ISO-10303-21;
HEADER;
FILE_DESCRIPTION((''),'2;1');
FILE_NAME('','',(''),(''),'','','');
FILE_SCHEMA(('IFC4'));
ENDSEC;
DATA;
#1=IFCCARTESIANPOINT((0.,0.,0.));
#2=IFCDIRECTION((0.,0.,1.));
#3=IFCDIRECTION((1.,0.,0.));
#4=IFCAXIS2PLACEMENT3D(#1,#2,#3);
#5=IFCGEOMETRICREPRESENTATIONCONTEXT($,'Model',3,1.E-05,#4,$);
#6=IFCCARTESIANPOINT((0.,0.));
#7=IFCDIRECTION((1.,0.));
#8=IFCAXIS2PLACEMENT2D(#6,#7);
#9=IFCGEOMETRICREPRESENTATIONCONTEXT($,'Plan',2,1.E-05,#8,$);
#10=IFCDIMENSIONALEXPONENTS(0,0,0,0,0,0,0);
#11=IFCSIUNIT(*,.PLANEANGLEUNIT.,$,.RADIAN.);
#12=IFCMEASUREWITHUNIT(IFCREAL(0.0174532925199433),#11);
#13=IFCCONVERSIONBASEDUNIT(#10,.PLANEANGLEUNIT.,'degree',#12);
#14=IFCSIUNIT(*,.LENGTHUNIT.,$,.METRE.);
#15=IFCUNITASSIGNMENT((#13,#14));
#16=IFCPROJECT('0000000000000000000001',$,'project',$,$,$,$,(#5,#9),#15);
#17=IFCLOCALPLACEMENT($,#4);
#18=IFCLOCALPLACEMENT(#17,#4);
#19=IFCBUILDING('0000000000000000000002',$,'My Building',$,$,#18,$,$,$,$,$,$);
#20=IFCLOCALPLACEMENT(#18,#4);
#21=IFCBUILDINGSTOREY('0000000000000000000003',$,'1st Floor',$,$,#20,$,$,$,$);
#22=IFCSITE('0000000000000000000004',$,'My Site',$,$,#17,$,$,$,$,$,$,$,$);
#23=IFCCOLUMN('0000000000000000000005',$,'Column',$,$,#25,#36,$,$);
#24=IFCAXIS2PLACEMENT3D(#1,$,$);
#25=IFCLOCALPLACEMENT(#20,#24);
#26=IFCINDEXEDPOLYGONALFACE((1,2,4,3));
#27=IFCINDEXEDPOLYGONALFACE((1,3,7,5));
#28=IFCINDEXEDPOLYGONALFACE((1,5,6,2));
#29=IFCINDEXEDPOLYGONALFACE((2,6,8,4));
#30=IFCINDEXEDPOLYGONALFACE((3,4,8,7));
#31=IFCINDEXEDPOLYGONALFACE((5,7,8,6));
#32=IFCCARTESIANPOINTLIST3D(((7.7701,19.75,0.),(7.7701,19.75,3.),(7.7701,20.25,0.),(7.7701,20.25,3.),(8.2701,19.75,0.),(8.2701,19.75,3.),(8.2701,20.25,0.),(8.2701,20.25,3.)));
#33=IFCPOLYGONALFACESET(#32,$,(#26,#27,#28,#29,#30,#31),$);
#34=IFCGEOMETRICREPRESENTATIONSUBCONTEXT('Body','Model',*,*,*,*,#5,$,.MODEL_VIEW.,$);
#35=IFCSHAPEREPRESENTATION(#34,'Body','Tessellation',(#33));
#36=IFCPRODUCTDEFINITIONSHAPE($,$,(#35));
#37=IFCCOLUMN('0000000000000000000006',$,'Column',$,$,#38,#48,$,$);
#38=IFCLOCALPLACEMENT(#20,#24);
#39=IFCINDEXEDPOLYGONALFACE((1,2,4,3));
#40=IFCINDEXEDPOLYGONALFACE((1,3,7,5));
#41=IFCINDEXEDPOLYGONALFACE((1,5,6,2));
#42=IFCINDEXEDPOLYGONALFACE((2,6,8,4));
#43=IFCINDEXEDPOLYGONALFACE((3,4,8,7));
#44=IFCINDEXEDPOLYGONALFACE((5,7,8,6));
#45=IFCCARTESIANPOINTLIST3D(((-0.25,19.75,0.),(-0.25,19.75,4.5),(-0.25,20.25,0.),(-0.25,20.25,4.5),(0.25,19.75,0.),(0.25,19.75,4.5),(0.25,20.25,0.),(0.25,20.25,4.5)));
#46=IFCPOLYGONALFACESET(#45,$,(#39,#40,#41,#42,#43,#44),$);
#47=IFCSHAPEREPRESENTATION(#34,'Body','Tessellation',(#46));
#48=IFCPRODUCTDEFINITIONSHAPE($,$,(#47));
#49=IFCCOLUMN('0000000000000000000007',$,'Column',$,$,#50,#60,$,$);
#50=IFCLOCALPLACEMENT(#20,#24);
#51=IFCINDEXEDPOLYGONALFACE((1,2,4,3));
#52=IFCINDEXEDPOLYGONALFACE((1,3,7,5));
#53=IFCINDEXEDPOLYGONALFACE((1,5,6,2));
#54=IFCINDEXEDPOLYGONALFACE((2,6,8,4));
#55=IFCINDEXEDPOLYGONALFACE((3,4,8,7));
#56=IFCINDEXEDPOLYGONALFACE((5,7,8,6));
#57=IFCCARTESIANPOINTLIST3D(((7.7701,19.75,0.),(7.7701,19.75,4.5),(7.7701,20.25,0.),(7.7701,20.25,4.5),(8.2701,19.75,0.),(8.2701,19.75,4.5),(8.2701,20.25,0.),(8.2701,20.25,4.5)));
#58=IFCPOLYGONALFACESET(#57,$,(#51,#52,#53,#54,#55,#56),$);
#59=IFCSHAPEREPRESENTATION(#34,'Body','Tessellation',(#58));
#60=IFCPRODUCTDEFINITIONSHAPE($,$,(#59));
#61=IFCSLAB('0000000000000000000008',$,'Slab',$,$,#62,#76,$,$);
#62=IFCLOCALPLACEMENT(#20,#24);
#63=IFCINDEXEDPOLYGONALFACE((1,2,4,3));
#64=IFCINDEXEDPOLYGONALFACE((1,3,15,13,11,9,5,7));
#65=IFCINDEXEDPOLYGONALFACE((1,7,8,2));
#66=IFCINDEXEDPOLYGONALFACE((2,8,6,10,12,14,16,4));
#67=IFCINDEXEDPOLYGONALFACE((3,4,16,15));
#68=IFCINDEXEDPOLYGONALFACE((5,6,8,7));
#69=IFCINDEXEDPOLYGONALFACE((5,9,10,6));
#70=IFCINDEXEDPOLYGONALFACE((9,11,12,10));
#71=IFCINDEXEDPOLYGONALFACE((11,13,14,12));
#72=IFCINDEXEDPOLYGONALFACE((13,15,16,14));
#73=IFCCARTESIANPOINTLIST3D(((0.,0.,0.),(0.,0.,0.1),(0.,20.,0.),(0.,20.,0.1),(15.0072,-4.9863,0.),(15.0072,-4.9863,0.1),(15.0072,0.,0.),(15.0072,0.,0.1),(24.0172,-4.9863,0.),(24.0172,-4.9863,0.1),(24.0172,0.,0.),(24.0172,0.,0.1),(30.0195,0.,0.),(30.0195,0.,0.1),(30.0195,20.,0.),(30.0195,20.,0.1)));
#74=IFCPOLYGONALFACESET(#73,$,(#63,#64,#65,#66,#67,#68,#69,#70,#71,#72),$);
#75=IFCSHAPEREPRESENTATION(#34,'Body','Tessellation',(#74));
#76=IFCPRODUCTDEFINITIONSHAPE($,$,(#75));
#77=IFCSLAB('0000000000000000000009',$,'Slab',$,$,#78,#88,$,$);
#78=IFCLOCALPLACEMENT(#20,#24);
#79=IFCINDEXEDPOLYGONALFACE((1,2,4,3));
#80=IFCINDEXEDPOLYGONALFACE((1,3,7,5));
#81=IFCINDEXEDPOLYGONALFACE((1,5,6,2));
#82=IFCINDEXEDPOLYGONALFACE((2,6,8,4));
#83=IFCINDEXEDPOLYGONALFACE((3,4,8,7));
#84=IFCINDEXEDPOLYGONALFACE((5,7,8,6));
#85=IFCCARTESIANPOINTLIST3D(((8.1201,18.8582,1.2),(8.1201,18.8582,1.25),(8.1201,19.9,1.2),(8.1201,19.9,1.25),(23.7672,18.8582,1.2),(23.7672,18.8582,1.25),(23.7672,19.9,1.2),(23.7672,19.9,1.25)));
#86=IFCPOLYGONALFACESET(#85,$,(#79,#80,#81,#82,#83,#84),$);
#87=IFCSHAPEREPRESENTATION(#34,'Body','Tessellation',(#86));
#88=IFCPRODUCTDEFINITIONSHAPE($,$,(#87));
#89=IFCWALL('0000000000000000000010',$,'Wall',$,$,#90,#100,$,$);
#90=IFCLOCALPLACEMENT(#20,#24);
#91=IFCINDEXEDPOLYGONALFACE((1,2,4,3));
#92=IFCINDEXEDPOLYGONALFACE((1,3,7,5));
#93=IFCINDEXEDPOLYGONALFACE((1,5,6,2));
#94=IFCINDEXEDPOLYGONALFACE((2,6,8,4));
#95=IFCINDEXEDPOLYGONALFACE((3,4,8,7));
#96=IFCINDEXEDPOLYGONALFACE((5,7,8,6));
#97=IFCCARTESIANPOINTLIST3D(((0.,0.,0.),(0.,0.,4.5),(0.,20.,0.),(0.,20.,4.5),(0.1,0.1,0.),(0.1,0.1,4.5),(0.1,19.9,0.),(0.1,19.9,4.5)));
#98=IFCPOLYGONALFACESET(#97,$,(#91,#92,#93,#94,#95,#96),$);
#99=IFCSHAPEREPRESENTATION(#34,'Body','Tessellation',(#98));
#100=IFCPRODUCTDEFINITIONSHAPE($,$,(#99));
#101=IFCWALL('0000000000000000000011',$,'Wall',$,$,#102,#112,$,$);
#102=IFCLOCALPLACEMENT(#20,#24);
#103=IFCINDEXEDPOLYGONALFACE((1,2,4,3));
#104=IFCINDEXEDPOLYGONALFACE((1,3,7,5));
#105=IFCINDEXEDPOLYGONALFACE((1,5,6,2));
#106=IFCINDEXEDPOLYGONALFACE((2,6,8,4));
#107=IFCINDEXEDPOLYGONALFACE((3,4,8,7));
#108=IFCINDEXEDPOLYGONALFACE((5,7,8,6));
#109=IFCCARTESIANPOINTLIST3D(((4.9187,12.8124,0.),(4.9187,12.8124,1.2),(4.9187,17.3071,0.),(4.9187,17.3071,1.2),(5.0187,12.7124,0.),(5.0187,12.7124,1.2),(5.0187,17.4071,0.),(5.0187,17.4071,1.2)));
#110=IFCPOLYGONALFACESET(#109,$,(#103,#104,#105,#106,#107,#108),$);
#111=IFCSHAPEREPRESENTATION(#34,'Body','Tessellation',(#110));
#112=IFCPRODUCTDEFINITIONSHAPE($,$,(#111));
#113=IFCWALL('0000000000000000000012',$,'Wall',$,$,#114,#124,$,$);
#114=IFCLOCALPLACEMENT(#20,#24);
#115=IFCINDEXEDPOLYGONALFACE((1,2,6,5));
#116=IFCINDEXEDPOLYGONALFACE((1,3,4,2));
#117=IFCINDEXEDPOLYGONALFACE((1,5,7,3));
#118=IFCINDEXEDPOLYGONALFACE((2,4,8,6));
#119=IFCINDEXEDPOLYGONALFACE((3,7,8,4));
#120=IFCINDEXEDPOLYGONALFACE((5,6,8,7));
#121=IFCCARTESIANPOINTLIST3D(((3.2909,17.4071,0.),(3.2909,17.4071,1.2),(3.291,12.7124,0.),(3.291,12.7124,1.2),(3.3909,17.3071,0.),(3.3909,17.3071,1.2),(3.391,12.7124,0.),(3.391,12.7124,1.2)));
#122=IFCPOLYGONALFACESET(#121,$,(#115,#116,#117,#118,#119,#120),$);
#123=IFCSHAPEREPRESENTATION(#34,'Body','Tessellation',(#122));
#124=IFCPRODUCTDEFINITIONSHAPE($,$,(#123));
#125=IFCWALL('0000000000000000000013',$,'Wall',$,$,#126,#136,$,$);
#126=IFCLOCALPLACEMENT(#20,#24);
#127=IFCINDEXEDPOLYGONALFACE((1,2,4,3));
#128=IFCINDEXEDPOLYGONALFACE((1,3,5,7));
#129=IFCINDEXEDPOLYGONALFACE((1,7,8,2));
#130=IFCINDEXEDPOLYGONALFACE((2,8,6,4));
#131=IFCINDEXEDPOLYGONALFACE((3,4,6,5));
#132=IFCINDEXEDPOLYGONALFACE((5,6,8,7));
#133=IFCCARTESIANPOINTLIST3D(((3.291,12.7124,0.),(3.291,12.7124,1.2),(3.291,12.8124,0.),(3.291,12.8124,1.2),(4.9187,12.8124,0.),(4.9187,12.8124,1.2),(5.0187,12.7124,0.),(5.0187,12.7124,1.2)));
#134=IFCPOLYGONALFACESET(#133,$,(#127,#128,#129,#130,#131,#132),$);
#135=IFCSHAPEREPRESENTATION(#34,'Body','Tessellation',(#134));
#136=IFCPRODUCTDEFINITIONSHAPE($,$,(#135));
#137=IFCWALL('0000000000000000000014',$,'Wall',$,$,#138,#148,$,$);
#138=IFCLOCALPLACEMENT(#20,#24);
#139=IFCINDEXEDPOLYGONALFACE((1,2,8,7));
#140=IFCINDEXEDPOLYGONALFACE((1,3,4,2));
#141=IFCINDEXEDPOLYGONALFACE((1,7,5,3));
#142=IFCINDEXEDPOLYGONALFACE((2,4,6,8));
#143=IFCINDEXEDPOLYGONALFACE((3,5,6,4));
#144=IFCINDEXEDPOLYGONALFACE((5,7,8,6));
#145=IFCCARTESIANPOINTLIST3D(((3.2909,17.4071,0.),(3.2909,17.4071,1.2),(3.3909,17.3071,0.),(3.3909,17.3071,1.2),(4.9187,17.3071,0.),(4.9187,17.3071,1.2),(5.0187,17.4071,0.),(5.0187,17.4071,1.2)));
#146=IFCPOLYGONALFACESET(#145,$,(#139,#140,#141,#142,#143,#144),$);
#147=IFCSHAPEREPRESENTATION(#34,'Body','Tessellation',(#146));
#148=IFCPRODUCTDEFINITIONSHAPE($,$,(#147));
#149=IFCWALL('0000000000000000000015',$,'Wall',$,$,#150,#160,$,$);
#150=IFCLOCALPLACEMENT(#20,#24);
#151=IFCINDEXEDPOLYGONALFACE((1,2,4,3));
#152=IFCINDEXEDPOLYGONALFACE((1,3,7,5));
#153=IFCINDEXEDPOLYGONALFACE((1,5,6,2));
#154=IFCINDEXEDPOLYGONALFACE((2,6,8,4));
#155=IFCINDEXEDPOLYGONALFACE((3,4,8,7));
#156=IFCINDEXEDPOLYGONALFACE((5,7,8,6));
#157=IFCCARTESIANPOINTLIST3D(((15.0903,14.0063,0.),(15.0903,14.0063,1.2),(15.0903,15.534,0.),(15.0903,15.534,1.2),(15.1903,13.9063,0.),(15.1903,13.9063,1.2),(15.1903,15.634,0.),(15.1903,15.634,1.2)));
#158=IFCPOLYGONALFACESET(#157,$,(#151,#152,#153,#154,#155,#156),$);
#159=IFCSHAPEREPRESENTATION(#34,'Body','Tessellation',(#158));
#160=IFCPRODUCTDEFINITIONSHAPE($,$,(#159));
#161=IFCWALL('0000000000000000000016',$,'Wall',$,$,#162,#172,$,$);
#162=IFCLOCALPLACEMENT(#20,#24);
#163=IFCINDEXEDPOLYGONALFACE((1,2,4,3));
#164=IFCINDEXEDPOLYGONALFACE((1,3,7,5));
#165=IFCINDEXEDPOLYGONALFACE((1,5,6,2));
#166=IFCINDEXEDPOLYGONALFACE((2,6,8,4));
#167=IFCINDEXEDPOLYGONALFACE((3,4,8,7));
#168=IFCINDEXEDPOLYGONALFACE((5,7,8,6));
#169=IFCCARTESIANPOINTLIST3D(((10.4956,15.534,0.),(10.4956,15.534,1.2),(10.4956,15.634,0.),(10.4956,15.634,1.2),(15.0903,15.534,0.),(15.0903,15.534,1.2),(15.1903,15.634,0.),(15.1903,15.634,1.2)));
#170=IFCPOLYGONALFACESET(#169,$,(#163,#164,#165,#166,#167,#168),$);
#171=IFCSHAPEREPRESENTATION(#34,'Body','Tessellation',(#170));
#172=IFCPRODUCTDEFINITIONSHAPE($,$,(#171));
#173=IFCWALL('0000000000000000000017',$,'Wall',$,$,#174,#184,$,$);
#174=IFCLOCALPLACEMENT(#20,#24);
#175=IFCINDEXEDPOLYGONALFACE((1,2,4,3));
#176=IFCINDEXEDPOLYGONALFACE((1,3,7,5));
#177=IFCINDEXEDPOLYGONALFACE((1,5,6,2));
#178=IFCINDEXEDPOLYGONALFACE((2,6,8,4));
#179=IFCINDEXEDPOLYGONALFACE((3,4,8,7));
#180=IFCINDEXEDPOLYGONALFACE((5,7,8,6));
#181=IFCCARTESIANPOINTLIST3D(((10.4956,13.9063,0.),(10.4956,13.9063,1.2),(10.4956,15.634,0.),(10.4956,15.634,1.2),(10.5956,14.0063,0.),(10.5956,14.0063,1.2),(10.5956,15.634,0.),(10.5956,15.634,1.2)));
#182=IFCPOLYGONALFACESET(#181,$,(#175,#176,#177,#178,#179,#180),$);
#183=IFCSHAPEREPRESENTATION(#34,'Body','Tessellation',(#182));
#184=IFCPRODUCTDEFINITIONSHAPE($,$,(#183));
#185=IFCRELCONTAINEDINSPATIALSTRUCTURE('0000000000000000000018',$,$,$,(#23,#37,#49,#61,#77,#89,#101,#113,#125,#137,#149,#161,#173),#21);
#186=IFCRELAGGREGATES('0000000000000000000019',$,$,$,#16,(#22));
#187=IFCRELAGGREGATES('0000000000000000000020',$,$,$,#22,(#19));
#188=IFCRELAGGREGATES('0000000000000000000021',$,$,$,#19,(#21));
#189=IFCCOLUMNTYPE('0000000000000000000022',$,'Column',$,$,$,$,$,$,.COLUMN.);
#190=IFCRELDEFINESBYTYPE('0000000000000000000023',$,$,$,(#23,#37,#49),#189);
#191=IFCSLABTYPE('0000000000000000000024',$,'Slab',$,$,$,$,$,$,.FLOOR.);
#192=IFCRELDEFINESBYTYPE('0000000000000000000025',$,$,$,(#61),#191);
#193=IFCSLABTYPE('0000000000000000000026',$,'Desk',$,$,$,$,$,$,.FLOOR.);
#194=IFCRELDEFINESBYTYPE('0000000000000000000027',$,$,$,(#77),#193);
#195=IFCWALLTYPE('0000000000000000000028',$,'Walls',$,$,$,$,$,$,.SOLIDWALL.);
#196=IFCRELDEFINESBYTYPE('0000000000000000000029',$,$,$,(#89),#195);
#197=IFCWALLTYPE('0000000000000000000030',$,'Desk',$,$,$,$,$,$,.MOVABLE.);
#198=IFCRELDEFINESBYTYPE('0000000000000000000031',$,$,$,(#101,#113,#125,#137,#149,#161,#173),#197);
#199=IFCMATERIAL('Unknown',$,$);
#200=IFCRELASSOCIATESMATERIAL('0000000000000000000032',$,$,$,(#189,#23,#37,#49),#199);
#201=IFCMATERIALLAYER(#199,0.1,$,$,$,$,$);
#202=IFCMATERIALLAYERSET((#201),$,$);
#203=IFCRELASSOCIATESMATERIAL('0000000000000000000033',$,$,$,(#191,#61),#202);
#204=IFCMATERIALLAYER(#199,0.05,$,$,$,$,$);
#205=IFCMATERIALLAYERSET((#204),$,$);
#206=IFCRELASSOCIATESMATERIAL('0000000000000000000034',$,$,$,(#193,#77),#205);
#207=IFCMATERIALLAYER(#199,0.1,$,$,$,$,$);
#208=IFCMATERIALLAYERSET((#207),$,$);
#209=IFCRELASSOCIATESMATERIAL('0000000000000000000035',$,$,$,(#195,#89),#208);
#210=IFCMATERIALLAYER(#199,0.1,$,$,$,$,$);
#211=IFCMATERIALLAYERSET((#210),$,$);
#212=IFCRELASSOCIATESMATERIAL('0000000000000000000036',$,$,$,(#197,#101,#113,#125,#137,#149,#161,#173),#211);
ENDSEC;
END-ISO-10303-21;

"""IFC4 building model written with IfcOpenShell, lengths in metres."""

from ifc_helpers import new_model, entity, si_unit, converted_unit, frame, origin_with_axes, origin_2d_with_axis, place, context, subcontext, project, spatial, line, indexed_curve, rectangle, outline, extrude, material, layer, layer_set, layer_usage, material_profile, profile_set, profile_usage, type_object, element, save


model = new_model("IFC4")

# Units and contexts
model_context = context("Model", 3, precision=1e-05, world=origin_with_axes())
plan_context = context("Plan", 2, precision=1e-05, world=origin_2d_with_axis())
body_context_1 = subcontext(model_context, "Body", "Model", "MODEL_VIEW")
ifc_project = project(units=[converted_unit("PLANEANGLEUNIT", "degree", entity("IfcReal", 0.0174532925199433), si_unit("PLANEANGLEUNIT", "RADIAN"), dimensions=[0, 0, 0, 0, 0, 0, 0]), si_unit("LENGTHUNIT", "METRE")], contexts=[model_context, plan_context])

# Site, building, storey
site_placement = place(None, origin_with_axes())
site = spatial("IfcSite", under=ifc_project, at=site_placement, Name="My Site")
building_placement = place(site_placement, origin_with_axes())
building = spatial("IfcBuilding", under=site, at=building_placement, Name="My Building")
storey_placement = place(building_placement, origin_with_axes())
storey = spatial("IfcBuildingStorey", under=building, at=storey_placement, Name="1st Floor")

# Columns
ifc_material = material(Name="Unknown")
ifc_material_profile = material_profile(ifc_material, rectangle(XDim=0.5, YDim=0.5))
ifc_profile_set = profile_set([ifc_material_profile])
ifc_profile_usage_1 = profile_usage(ifc_profile_set, cardinal=5)
column_type = type_object("IfcColumnType", Name="Column", PredefinedType="COLUMN", material=ifc_profile_set)
column_1_placement = place(storey_placement, frame((8.0201, 20.0, 0.0), z_axis=(0.0, 0.0, 1.0), x_axis=(1.0, 0.0, 0.0)))
element("IfcColumn", 1, at=column_1_placement, inside=storey, type_object=column_type, material=ifc_profile_usage_1, Name="Column", context=body_context_1, shape_type="SweptSolid", body=[
    extrude(rectangle(XDim=0.5, YDim=0.5), origin_with_axes(), (0.0, 0.0, 1.0), 3.0),
])
ifc_profile_usage_2 = profile_usage(ifc_profile_set, cardinal=5)
column_2_placement = place(storey_placement, frame((0.0, 20.0, 0.0), z_axis=(0.0, 0.0, 1.0), x_axis=(1.0, 0.0, 0.0)))
element("IfcColumn", 2, at=column_2_placement, inside=storey, type_object=column_type, material=ifc_profile_usage_2, Name="Column", context=body_context_1, shape_type="SweptSolid", body=[
    extrude(rectangle(XDim=0.5, YDim=0.5), origin_with_axes(), (0.0, 0.0, 1.0), 4.5),
])
ifc_profile_usage_3 = profile_usage(ifc_profile_set, cardinal=5)
column_3_placement = place(storey_placement, frame((8.0201, 20.0, 0.0), z_axis=(0.0, 0.0, 1.0), x_axis=(1.0, 0.0, 0.0)))
element("IfcColumn", 3, at=column_3_placement, inside=storey, type_object=column_type, material=ifc_profile_usage_3, Name="Column", context=body_context_1, shape_type="SweptSolid", body=[
    extrude(rectangle(XDim=0.5, YDim=0.5), origin_with_axes(), (0.0, 0.0, 1.0), 4.5),
])

# Slabs
ifc_layer_1 = layer(ifc_material, 0.1)
ifc_layer_set_1 = layer_set([ifc_layer_1])
ifc_layer_usage_1 = layer_usage(ifc_layer_set_1, "AXIS3", "POSITIVE", -0.1)
slab_type_1 = type_object("IfcSlabType", Name="Slab", PredefinedType="FLOOR", material=ifc_layer_set_1)
slab_1_placement = place(storey_placement, frame((0.0, 20.0, 0.1), z_axis=(0.0, 0.0, 1.0), x_axis=(1.0, 0.0, 0.0)))
element("IfcSlab", 4, at=slab_1_placement, inside=storey, type_object=slab_type_1, material=ifc_layer_usage_1, Name="Slab", context=body_context_1, shape_type="SweptSolid", body=[
    extrude(outline(indexed_curve([(0.0, 0.0), (30.0195, 0.0), (30.0195, -20.0), (24.0172, -20.0), (24.0172, -24.9863), (15.0072, -24.9863), (15.0072, -20.0), (0.0, -20.0), (0.0, 0.0)])), frame((0.0, 0.0, -0.1), z_axis=(0.0, 0.0, 1.0), x_axis=(1.0, 0.0, 0.0)), (0.0, 0.0, 1.0), 0.1),
])
ifc_layer_2 = layer(ifc_material, 0.05)
ifc_layer_set_2 = layer_set([ifc_layer_2])
slab_type_2 = type_object("IfcSlabType", Name="Desk", PredefinedType="FLOOR", material=ifc_layer_set_2)
ifc_layer_usage_2 = layer_usage(ifc_layer_set_2, "AXIS3", "POSITIVE", -0.05)
slab_2_placement = place(storey_placement, frame((8.1201, 18.8582, 1.25), z_axis=(0.0, 0.0, 1.0), x_axis=(1.0, 0.0, 0.0)))
element("IfcSlab", 5, at=slab_2_placement, inside=storey, type_object=slab_type_2, material=ifc_layer_usage_2, Name="Slab", context=body_context_1, shape_type="SweptSolid", body=[
    extrude(outline(indexed_curve([(0.0, 0.0), (15.647, 0.0), (15.647, 1.0417), (0.0, 1.0417), (0.0, 0.0)])), frame((0.0, 0.0, -0.05), z_axis=(0.0, 0.0, 1.0), x_axis=(1.0, 0.0, 0.0)), (0.0, 0.0, 1.0), 0.05),
])

# Wall
ifc_layer_3 = layer(ifc_material, 0.1)
ifc_layer_set_3 = layer_set([ifc_layer_3])
ifc_layer_usage_3 = layer_usage(ifc_layer_set_3, "AXIS2", "POSITIVE", 0.0)
wall_type_1 = type_object("IfcWallType", Name="Walls", PredefinedType="SOLIDWALL", material=ifc_layer_set_3)
wall_1_placement = place(storey_placement, frame((0.0, 20.0, 0.0), z_axis=(0.0, 0.0, 1.0), x_axis=(0.0, -1.0, 0.0)))
element("IfcWall", 6, at=wall_1_placement, inside=storey, type_object=wall_type_1, material=ifc_layer_usage_3, Name="Wall", context=body_context_1, shape_type="SweptSolid", body=[
    extrude(outline(indexed_curve([(0.0, 0.0), (0.1, 0.1), (19.9, 0.1), (20.0, 0.0)], segments=[line(1, 2, 3, 4, 1)])), origin_with_axes(), (0.0, 0.0, 1.0), 4.5),
])

# Walls
ifc_layer_4 = layer(ifc_material, 0.1)
ifc_layer_set_4 = layer_set([ifc_layer_4])
ifc_layer_usage_4 = layer_usage(ifc_layer_set_4, "AXIS2", "POSITIVE", 0.0)
wall_type_2 = type_object("IfcWallType", Name="Desk", PredefinedType="MOVABLE", material=ifc_layer_set_4)
wall_2_placement = place(storey_placement, frame((5.0187, 12.7124, 0.0), z_axis=(0.0, 0.0, 1.0), x_axis=(0.0, 1.0, 0.0)))
element("IfcWall", 7, at=wall_2_placement, inside=storey, type_object=wall_type_2, material=ifc_layer_usage_4, Name="Wall", context=body_context_1, shape_type="SweptSolid", body=[
    extrude(outline(indexed_curve([(0.0, 0.0), (0.1, 0.1), (4.5947, 0.1), (4.6947, 0.0)], segments=[line(1, 2, 3, 4, 1)])), origin_with_axes(), (0.0, 0.0, 1.0), 1.2),
])
ifc_layer_usage_5 = layer_usage(ifc_layer_set_4, "AXIS2", "POSITIVE", 0.0)
wall_3_placement = place(storey_placement, frame((3.2909, 17.4071, 0.0), z_axis=(0.0, 0.0, 1.0), x_axis=(0.0, -1.0, 0.0)))
element("IfcWall", 8, at=wall_3_placement, inside=storey, type_object=wall_type_2, material=ifc_layer_usage_5, Name="Wall", context=body_context_1, shape_type="SweptSolid", body=[
    extrude(outline(indexed_curve([(0.0, 0.0), (0.1, 0.1), (4.6947, 0.1), (4.6947, 0.0)], segments=[line(1, 2, 3, 4, 1)])), origin_with_axes(), (0.0, 0.0, 1.0), 1.2),
])
ifc_layer_usage_6 = layer_usage(ifc_layer_set_4, "AXIS2", "POSITIVE", 0.0)
wall_4_placement = place(storey_placement, frame((3.291, 12.7124, 0.0), z_axis=(0.0, 0.0, 1.0), x_axis=(1.0, 0.0, 0.0)))
element("IfcWall", 9, at=wall_4_placement, inside=storey, type_object=wall_type_2, material=ifc_layer_usage_6, Name="Wall", context=body_context_1, shape_type="SweptSolid", body=[
    extrude(outline(indexed_curve([(0.0, 0.0), (0.0, 0.1), (1.6277, 0.1), (1.7277, 0.0)], segments=[line(1, 2, 3, 4, 1)])), origin_with_axes(), (0.0, 0.0, 1.0), 1.2),
])
ifc_layer_usage_7 = layer_usage(ifc_layer_set_4, "AXIS2", "POSITIVE", 0.0)
wall_5_placement = place(storey_placement, frame((5.0187, 17.4071, 0.0), z_axis=(0.0, 0.0, 1.0), x_axis=(-1.0, 0.0, 0.0)))
element("IfcWall", 10, at=wall_5_placement, inside=storey, type_object=wall_type_2, material=ifc_layer_usage_7, Name="Wall", context=body_context_1, shape_type="SweptSolid", body=[
    extrude(outline(indexed_curve([(0.0, 0.0), (0.1, 0.1), (1.6277, 0.1), (1.7277, 0.0)], segments=[line(1, 2, 3, 4, 1)])), origin_with_axes(), (0.0, 0.0, 1.0), 1.2),
])
ifc_layer_usage_8 = layer_usage(ifc_layer_set_4, "AXIS2", "POSITIVE", 0.0)
wall_6_placement = place(storey_placement, frame((15.1903, 13.9063, 0.0), z_axis=(0.0, 0.0, 1.0), x_axis=(0.0, 1.0, 0.0)))
element("IfcWall", 11, at=wall_6_placement, inside=storey, type_object=wall_type_2, material=ifc_layer_usage_8, Name="Wall", context=body_context_1, shape_type="SweptSolid", body=[
    extrude(outline(indexed_curve([(0.0, 0.0), (0.1, 0.1), (1.6277, 0.1), (1.7277, 0.0)], segments=[line(1, 2, 3, 4, 1)])), origin_with_axes(), (0.0, 0.0, 1.0), 1.2),
])
ifc_layer_usage_9 = layer_usage(ifc_layer_set_4, "AXIS2", "POSITIVE", 0.0)
wall_7_placement = place(storey_placement, frame((15.1903, 15.634, 0.0), z_axis=(0.0, 0.0, 1.0), x_axis=(-1.0, -0.000001, 0.0)))
element("IfcWall", 12, at=wall_7_placement, inside=storey, type_object=wall_type_2, material=ifc_layer_usage_9, Name="Wall", context=body_context_1, shape_type="SweptSolid", body=[
    extrude(outline(indexed_curve([(0.0, 0.0), (0.1, 0.1), (4.6947, 0.1), (4.6947, 0.0)], segments=[line(1, 2, 3, 4, 1)])), origin_with_axes(), (0.0, 0.0, 1.0), 1.2),
])
ifc_layer_usage_10 = layer_usage(ifc_layer_set_4, "AXIS2", "POSITIVE", 0.0)
wall_8_placement = place(storey_placement, frame((10.4956, 15.634, 0.0), z_axis=(0.0, 0.0, 1.0), x_axis=(0.000001, -1.0, 0.0)))
element("IfcWall", 13, at=wall_8_placement, inside=storey, type_object=wall_type_2, material=ifc_layer_usage_10, Name="Wall", context=body_context_1, shape_type="SweptSolid", body=[
    extrude(outline(indexed_curve([(0.0, 0.0), (0.0, 0.1), (1.6277, 0.1), (1.7277, 0.0)], segments=[line(1, 2, 3, 4, 1)])), origin_with_axes(), (0.0, 0.0, 1.0), 1.2),
])

save(model, "model.ifc")
